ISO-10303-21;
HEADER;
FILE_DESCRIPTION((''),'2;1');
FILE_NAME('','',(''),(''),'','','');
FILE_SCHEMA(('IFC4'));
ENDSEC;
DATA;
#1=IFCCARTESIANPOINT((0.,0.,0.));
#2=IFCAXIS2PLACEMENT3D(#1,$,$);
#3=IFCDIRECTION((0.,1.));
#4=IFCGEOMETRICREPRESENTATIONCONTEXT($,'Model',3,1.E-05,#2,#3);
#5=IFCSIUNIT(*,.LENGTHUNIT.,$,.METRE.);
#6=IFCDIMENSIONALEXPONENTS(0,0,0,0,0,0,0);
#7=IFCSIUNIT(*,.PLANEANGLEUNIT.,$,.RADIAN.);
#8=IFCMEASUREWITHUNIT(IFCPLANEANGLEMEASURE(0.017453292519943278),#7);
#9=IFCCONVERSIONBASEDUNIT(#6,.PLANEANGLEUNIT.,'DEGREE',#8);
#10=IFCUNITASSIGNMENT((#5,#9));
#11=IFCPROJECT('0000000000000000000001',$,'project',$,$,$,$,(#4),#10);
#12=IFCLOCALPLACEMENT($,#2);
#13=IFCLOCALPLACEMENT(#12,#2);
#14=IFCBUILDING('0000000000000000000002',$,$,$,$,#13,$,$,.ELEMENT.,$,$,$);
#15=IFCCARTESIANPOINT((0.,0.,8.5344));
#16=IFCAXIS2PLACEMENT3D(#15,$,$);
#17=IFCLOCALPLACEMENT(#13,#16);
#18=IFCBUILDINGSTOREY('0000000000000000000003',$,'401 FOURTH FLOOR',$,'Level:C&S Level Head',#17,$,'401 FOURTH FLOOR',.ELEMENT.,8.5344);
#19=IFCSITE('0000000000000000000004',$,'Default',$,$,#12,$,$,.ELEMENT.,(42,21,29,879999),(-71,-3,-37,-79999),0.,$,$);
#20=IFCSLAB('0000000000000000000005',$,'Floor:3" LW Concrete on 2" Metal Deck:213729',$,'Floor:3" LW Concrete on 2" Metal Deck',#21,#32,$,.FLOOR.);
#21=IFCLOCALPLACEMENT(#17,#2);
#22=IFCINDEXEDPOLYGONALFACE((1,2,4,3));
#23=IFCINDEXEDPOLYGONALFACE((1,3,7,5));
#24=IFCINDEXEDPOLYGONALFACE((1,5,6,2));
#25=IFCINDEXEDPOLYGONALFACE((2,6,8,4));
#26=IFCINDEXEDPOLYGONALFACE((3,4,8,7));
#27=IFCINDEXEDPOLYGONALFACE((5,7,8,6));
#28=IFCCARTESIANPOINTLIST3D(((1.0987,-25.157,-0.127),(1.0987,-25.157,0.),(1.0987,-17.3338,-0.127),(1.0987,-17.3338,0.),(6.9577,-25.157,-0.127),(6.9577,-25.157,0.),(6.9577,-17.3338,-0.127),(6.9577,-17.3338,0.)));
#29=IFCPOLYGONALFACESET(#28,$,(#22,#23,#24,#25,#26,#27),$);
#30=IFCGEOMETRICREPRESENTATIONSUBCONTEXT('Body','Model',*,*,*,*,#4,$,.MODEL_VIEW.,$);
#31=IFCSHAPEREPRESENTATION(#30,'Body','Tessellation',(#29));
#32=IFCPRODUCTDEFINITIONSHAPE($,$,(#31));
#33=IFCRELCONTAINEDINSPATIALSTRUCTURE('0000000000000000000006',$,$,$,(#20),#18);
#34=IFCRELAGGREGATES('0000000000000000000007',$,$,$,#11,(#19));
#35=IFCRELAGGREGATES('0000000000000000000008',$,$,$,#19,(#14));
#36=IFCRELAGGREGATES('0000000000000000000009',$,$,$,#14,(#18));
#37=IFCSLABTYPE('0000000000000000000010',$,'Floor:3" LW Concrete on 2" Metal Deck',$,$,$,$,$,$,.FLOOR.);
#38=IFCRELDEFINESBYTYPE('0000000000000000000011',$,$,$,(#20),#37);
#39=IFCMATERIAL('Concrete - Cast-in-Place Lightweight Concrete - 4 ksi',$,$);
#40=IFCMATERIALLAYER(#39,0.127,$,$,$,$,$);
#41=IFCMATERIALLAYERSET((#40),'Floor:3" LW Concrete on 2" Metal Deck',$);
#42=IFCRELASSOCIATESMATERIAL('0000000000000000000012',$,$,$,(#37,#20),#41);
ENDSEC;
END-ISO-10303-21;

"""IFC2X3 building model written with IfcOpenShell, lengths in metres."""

from ifc_helpers import new_model, entity, si_unit, converted_unit, direction, frame, frame_2d, origin, place, context, subcontext, project, spatial, rectangle, extrude, material, layer, layer_set, layer_usage, type_object, element, save


model = new_model("IFC2X3")

# Units and contexts
model_context = context("Model", 3, precision=1e-05, world=origin(), true_north=direction((0.0, 1.0)))
body_context = subcontext(model_context, "Body", "Model", "MODEL_VIEW")
ifc_project = project(units=[si_unit("LENGTHUNIT", "METRE"), converted_unit("PLANEANGLEUNIT", "DEGREE", entity("IfcPlaneAngleMeasure", 0.017453292519943278), si_unit("PLANEANGLEUNIT", "RADIAN"), dimensions=[0, 0, 0, 0, 0, 0, 0])], contexts=[model_context])

# Site, building, storey
site_placement = place(None, origin())
site = spatial("IfcSite", under=ifc_project, at=site_placement, Name="Default", CompositionType="ELEMENT", RefLatitude=(42, 21, 29, 879999), RefLongitude=(-71, -3, -37, -79999), RefElevation=0.0)
building_placement = place(site_placement, origin())
building = spatial("IfcBuilding", under=site, at=building_placement, CompositionType="ELEMENT")
storey_placement = place(building_placement, frame((0.0, 0.0, 8.5344)))
storey = spatial("IfcBuildingStorey", under=building, at=storey_placement, Name="401 FOURTH FLOOR", ObjectType="Level:C&S Level Head", LongName="401 FOURTH FLOOR", CompositionType="ELEMENT", Elevation=8.5344)

# Slab
ifc_material_1 = material(Name="Concrete - Cast-in-Place Lightweight Concrete - 4 ksi")
ifc_layer = layer(ifc_material_1, 0.127)
ifc_layer_set = layer_set([ifc_layer], Name="Floor:3\" LW Concrete on 2\" Metal Deck")
slab_type = type_object("IfcSlabType", Name="Floor:3\" LW Concrete on 2\" Metal Deck", PredefinedType="FLOOR", material=ifc_layer_set)
ifc_layer_usage_1 = layer_usage(ifc_layer_set, "AXIS3", "POSITIVE", 0.0)
slab_1_placement = place(storey_placement, origin())
element("IfcSlab", 1, at=slab_1_placement, inside=storey, type_object=slab_type, material=ifc_layer_usage_1, Name="Floor:3\" LW Concrete on 2\" Metal Deck:213729", ObjectType="Floor:3\" LW Concrete on 2\" Metal Deck", PredefinedType="FLOOR", context=body_context, shape_type="SweptSolid", body=[
    extrude(rectangle(XDim=7.8232, YDim=5.859, at=frame_2d((0.0, 0.0), x_axis=(1.0, 0.0))), frame((4.0282, -21.2454, 0.0), z_axis=(0.0, 0.0, -1.0), x_axis=(0.0, 1.0, 0.0)), (0.0, 0.0, 1.0), 0.127),
])

save(model, "model.ifc")
